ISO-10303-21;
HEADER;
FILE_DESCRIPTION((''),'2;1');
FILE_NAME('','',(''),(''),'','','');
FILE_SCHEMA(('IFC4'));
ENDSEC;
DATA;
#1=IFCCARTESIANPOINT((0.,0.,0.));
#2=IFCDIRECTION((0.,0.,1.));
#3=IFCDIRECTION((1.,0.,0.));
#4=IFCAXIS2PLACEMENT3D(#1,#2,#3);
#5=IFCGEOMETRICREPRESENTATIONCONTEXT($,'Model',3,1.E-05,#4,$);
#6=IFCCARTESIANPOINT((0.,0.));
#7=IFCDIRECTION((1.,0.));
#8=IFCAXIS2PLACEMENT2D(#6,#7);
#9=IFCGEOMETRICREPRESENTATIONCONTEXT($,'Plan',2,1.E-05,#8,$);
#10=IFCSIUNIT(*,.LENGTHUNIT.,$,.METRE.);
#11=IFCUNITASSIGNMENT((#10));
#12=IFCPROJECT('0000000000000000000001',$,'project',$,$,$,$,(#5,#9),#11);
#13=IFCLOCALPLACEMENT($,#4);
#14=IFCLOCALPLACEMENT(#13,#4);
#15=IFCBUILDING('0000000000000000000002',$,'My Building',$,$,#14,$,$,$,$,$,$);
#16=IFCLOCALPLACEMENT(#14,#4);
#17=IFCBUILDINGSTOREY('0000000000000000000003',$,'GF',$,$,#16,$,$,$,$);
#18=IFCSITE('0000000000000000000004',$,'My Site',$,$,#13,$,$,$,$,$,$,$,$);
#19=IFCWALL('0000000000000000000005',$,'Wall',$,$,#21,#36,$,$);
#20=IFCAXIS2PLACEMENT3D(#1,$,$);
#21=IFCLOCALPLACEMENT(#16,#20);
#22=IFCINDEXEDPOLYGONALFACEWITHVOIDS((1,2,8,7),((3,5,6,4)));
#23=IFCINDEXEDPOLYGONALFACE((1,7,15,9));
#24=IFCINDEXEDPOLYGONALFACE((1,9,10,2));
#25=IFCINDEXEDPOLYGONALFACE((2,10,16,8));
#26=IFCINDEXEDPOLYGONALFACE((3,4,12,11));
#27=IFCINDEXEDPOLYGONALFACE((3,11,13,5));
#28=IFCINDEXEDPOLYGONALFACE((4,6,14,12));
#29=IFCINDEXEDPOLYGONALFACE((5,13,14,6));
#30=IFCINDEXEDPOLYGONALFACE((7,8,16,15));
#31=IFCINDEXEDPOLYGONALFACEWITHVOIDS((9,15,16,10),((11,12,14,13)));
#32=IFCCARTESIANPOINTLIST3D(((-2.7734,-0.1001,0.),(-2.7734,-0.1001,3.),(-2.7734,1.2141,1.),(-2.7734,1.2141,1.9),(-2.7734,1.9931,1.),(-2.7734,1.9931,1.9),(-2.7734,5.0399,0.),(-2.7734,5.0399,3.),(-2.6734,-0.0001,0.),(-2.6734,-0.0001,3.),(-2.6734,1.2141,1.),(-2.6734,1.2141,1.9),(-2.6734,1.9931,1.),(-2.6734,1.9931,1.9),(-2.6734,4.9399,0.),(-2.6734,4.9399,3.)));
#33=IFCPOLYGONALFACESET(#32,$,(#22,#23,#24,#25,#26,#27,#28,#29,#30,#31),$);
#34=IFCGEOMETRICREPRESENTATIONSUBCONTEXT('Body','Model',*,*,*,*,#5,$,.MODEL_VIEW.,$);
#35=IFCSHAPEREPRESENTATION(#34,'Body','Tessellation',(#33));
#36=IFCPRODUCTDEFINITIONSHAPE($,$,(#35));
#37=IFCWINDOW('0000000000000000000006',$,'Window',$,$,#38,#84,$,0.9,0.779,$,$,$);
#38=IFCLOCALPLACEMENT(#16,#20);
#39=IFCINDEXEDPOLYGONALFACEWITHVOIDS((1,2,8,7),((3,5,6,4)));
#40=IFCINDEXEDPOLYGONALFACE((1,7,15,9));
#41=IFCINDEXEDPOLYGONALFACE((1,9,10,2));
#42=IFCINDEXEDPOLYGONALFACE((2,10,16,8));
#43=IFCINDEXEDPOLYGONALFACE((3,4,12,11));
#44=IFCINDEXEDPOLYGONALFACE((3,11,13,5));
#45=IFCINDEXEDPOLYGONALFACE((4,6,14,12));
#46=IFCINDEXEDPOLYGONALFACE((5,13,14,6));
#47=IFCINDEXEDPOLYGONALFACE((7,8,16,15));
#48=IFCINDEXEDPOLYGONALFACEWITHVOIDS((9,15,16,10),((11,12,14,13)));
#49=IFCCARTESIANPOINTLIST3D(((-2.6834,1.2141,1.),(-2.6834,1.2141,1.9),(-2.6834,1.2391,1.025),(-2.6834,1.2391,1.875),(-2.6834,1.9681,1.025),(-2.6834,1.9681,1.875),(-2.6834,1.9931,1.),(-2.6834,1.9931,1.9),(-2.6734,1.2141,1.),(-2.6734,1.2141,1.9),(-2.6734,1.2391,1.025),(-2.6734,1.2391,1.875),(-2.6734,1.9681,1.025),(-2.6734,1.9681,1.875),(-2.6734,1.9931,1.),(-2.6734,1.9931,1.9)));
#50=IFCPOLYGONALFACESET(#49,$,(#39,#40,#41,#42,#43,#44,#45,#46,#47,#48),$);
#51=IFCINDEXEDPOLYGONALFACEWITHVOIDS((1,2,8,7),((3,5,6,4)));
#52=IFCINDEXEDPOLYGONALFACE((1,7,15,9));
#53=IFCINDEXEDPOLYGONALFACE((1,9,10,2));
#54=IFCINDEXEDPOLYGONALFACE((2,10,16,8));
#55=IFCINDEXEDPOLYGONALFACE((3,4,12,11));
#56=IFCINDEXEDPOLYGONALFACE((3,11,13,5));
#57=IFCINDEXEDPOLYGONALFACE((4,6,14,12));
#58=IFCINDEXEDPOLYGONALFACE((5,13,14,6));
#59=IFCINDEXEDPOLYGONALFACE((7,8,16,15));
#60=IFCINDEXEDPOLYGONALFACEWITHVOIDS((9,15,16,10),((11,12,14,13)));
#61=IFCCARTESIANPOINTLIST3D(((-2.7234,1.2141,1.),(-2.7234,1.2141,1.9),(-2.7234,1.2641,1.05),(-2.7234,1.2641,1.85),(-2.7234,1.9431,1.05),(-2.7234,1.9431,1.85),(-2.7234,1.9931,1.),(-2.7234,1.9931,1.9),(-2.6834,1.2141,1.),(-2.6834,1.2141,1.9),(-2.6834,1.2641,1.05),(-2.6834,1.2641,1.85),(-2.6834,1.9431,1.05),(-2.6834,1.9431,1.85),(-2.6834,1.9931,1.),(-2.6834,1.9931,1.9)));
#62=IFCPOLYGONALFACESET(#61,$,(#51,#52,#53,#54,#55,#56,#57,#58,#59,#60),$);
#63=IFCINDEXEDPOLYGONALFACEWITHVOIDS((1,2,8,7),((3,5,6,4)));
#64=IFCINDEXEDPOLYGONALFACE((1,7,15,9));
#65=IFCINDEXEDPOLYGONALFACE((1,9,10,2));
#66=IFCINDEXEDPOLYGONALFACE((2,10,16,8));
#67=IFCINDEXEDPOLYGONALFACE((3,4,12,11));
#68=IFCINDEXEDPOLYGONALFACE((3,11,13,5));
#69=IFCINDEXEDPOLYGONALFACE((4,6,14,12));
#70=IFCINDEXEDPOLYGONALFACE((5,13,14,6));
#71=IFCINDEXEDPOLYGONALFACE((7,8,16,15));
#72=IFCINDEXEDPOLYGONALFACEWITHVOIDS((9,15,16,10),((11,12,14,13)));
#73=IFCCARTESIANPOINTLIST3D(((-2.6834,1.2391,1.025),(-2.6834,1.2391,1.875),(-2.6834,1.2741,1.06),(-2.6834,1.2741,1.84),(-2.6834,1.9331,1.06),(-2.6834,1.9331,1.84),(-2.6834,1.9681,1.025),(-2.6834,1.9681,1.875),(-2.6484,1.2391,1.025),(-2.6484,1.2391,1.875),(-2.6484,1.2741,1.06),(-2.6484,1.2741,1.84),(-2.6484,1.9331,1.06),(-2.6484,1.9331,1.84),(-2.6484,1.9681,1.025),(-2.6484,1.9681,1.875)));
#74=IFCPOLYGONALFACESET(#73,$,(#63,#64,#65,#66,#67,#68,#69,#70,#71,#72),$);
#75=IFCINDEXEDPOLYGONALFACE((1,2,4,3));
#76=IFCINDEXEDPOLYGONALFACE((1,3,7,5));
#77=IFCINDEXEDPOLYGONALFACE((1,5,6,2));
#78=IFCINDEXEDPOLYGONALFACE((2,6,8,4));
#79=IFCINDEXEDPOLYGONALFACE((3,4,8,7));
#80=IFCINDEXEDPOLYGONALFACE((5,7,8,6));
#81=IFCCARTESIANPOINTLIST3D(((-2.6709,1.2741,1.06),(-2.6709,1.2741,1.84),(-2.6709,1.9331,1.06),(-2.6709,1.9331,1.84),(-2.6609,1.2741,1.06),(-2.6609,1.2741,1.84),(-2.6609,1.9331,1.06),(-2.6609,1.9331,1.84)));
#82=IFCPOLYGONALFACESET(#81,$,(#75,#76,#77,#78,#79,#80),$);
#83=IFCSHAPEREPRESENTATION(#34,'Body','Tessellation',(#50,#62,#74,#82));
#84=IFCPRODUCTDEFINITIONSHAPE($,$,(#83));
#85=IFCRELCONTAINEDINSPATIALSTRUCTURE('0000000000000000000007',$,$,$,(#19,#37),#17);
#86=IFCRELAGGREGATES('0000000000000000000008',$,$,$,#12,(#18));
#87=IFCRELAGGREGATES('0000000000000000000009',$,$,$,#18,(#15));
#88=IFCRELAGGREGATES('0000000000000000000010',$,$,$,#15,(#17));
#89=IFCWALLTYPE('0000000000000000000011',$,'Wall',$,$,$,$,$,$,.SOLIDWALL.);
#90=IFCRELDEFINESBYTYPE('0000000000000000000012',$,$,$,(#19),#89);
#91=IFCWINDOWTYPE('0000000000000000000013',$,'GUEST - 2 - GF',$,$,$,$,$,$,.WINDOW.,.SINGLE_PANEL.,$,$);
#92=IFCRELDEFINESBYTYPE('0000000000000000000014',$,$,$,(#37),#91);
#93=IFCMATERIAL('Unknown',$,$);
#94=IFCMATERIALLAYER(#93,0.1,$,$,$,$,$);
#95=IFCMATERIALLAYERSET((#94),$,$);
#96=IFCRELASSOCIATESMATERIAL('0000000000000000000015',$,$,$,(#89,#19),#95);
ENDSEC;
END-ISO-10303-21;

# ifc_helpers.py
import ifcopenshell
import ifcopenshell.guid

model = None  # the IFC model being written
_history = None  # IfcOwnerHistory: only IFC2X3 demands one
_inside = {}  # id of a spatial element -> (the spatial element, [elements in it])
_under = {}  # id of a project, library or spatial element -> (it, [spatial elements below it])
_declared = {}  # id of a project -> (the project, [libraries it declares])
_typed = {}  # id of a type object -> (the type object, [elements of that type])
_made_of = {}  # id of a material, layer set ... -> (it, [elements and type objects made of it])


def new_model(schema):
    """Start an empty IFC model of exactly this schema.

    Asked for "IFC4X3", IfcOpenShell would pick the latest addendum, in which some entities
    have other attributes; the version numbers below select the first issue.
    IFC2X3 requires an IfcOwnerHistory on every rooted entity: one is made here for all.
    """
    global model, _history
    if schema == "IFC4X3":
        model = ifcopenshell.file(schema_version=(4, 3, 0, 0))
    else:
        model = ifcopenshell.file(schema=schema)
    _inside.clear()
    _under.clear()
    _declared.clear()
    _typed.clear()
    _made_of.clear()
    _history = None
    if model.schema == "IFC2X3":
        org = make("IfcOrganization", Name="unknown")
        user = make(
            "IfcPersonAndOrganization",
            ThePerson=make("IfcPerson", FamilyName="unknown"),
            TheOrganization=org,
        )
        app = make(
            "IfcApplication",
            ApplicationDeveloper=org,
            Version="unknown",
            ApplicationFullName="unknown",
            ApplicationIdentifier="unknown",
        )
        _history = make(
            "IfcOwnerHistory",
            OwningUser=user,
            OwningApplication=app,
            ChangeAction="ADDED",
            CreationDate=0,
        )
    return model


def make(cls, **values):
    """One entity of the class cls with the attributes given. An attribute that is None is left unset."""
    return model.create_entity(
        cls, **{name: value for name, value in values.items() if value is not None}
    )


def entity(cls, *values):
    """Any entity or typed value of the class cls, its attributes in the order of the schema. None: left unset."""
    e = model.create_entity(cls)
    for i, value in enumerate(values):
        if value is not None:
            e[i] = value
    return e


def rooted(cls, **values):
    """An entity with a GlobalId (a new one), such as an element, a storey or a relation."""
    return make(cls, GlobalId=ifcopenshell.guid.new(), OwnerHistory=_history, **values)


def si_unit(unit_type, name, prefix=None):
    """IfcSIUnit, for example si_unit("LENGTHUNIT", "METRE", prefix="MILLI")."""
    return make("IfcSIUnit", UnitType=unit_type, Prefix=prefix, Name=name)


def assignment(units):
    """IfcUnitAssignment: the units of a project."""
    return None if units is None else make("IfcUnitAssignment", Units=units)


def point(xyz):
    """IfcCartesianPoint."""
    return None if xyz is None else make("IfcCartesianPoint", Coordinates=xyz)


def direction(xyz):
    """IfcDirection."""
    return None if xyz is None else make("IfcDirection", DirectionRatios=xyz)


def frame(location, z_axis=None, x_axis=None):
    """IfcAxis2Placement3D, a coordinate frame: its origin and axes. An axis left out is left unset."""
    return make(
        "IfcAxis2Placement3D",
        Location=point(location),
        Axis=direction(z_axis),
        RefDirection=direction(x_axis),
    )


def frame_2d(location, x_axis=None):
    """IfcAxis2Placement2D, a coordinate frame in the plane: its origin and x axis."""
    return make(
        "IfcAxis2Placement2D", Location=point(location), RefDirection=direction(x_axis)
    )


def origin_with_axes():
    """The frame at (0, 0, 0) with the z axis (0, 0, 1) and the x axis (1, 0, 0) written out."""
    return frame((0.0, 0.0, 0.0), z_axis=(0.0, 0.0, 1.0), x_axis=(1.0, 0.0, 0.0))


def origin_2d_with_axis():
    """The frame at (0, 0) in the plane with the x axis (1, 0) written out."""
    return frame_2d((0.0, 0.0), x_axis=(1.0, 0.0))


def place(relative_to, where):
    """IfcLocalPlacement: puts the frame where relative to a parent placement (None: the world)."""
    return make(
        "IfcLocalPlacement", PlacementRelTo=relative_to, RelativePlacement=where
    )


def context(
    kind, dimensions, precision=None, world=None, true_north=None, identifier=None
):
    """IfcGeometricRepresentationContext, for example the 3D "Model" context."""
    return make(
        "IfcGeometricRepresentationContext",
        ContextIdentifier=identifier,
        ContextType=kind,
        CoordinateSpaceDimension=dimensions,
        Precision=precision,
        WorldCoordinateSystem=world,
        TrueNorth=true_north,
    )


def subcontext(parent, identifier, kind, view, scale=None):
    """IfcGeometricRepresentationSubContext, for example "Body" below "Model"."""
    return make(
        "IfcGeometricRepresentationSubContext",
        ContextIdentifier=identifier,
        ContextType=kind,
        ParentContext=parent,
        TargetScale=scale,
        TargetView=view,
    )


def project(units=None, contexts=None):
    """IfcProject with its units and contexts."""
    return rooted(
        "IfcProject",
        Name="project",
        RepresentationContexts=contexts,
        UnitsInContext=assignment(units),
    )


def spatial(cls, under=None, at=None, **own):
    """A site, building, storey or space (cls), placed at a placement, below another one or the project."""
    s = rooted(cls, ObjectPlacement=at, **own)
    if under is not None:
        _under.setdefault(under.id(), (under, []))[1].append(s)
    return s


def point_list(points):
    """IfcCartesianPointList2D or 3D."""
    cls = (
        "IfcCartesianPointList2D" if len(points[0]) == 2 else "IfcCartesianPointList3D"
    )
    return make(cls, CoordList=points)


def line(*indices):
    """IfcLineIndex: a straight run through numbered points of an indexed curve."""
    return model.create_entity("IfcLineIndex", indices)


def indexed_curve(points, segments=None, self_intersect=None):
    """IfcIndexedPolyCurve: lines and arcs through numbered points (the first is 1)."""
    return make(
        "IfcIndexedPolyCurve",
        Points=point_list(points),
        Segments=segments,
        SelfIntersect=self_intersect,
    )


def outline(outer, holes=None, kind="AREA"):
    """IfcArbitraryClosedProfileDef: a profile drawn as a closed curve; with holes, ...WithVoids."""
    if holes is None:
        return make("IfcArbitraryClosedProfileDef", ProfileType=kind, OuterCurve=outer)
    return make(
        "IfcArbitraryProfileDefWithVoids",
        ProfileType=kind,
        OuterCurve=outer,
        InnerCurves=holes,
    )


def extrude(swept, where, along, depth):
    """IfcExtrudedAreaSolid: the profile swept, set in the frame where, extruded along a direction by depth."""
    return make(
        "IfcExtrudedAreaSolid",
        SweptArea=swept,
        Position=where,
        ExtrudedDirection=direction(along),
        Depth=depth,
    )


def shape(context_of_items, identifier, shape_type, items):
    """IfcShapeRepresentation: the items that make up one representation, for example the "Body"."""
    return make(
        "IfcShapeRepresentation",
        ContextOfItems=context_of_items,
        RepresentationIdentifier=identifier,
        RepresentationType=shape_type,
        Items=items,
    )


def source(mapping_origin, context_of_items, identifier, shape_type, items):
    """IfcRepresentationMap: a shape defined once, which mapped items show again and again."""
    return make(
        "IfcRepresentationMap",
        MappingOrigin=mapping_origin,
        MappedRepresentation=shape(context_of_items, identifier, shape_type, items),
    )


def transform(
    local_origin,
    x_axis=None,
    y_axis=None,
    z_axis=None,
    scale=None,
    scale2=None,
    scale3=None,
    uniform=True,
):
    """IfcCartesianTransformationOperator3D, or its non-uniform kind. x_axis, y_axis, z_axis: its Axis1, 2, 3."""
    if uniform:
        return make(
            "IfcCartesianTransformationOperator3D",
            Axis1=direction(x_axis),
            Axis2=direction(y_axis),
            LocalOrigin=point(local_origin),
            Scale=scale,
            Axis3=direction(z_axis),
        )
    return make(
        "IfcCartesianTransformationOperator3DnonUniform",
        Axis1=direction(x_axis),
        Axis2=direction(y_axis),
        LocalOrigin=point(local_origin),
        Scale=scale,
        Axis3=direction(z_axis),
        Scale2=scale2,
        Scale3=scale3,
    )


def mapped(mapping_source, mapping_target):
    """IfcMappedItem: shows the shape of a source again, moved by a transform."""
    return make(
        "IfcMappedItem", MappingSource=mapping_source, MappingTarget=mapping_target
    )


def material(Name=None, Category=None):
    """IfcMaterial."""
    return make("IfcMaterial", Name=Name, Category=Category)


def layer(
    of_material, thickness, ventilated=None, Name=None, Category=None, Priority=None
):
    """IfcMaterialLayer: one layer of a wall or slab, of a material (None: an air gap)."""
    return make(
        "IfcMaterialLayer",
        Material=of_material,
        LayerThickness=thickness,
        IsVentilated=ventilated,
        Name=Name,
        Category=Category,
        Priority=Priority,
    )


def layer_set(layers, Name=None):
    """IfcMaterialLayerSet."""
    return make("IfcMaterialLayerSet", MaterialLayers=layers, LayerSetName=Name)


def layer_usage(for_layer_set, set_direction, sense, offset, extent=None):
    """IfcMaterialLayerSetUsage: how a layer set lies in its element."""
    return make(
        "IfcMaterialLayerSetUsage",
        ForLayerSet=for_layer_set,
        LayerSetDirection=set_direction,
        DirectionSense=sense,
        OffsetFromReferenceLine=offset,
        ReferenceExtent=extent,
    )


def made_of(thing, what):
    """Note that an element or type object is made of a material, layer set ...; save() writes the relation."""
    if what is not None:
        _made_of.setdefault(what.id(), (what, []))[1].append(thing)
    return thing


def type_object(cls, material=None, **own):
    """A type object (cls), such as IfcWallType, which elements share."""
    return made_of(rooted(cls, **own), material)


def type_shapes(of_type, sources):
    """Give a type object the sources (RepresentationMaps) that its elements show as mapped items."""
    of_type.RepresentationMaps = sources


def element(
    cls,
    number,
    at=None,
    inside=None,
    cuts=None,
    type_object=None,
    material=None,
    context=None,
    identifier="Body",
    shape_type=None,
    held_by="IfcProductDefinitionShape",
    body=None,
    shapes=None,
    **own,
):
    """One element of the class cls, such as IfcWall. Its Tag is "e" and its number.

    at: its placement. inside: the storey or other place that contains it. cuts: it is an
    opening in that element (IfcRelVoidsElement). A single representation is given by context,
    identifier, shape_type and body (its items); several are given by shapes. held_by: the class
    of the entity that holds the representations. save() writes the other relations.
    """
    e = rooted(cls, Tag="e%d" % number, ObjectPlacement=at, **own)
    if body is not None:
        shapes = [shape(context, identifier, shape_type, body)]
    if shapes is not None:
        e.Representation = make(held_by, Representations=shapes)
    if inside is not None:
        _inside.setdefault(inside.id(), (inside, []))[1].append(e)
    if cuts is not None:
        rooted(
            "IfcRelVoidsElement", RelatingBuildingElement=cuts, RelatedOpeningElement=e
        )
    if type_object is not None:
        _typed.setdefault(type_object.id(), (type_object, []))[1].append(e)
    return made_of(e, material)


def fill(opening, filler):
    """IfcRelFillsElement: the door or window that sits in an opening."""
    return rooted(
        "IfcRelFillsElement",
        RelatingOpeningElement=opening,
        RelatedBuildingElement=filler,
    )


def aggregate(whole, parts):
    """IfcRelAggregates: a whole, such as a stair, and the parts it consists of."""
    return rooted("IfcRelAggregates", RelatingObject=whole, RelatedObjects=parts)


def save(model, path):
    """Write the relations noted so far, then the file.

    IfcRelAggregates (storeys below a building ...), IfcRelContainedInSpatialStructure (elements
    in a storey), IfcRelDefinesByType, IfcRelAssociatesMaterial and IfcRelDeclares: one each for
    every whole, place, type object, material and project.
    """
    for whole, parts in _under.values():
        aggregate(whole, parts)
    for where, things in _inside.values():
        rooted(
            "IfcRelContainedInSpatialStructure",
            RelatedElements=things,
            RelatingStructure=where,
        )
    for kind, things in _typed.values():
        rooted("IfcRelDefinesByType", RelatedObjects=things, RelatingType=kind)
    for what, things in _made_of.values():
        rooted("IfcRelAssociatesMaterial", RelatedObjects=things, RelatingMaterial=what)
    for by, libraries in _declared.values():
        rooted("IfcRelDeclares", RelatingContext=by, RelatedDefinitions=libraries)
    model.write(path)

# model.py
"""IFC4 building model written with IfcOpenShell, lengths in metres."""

from ifc_helpers import new_model, entity, si_unit, frame, origin_with_axes, origin_2d_with_axis, place, context, subcontext, project, spatial, line, indexed_curve, outline, extrude, shape, source, transform, mapped, material, layer, layer_set, layer_usage, type_object, type_shapes, element, fill, save


model = new_model("IFC4")

# Units and contexts
model_context = context("Model", 3, precision=1e-05, world=origin_with_axes())
plan_context = context("Plan", 2, precision=1e-05, world=origin_2d_with_axis())
body_context_1 = subcontext(model_context, "Body", "Model", "MODEL_VIEW")
body_context_2 = subcontext(plan_context, "Body", "Plan", "PLAN_VIEW")
ifc_project = project(units=[si_unit("LENGTHUNIT", "METRE")], contexts=[model_context, plan_context])

# Site, building, storey
site_placement = place(None, origin_with_axes())
site = spatial("IfcSite", under=ifc_project, at=site_placement, Name="My Site")
building_placement = place(site_placement, origin_with_axes())
building = spatial("IfcBuilding", under=site, at=building_placement, Name="My Building")
storey_placement = place(building_placement, origin_with_axes())
storey = spatial("IfcBuildingStorey", under=building, at=storey_placement, Name="GF")

# Shared definitions
ifc_material = material(Name="Unknown")

# Shared definitions
ifc_layer_1 = layer(ifc_material, 0.1)
ifc_layer_set_1 = layer_set([ifc_layer_1])
wall_type = type_object("IfcWallType", Name="Wall", PredefinedType="SOLIDWALL", material=ifc_layer_set_1)

# Wall, opening, window
ifc_layer_usage_1 = layer_usage(ifc_layer_set_1, "AXIS2", "POSITIVE", 0.0)
wall_1_placement = place(storey_placement, frame((-2.7734, 5.0399, 0.0), z_axis=(0.0, 0.0, 1.0), x_axis=(0.0, -1.0, 0.0)))
wall_1 = element("IfcWall", 1, at=wall_1_placement, inside=storey, type_object=wall_type, material=ifc_layer_usage_1, Name="Wall", context=body_context_1, shape_type="SweptSolid", body=[
    extrude(outline(indexed_curve([(0.0, 0.0), (0.1, 0.1), (5.04, 0.1), (5.14, 0.0)], segments=[line(1, 2, 3, 4, 1)])), origin_with_axes(), (0.0, 0.0, 1.0), 3.0),
])
shared_shape_1 = source(origin_with_axes(), body_context_1, "Body", "SweptSolid", [
    extrude(outline(indexed_curve([(0.0, 0.0), (0.779, 0.0), (0.779, 0.9), (0.0, 0.9)], segments=[line(1, 2, 3, 4, 1)])), frame((0.0, -0.6, 0.0), z_axis=(0.0, -1.0, 0.0), x_axis=(1.0, 0.0, 0.0)), (0.0, 0.0, -1.0), 1.2),
])
opening_1_placement = place(wall_1_placement, frame((3.0468, 0.0, 1.0), z_axis=(0.0, 0.0, 1.0), x_axis=(1.0, 0.0, 0.0)))
opening_1 = element("IfcOpeningElement", 2, at=opening_1_placement, cuts=wall_1, PredefinedType="OPENING", context=body_context_1, shape_type="MappedRepresentation", body=[
    mapped(shared_shape_1, transform((0.0, 0.0, 0.0), x_axis=(1.0, 0.0, 0.0), y_axis=(0.0, 1.0, 0.0), z_axis=(0.0, 0.0, 1.0), scale=1.0)),
])
window_type_1 = type_object("IfcWindowType", Name="GUEST - 2 - GF", PartitioningType="SINGLE_PANEL", PredefinedType="WINDOW")
shared_shape_2 = source(origin_with_axes(), body_context_1, "Body", "SweptSolid", [
    extrude(outline(indexed_curve([(0.0, 0.0), (0.779, 0.0), (0.779, 0.9), (0.0, 0.9)], segments=[line(1, 2, 3, 4, 1)]), holes=[indexed_curve([(0.025, 0.025), (0.754, 0.025), (0.754, 0.875), (0.025, 0.875)], segments=[line(1, 2, 3, 4, 1)])]), frame((0.0, 0.09, 0.0), z_axis=(0.0, -1.0, 0.0), x_axis=(1.0, 0.0, 0.0)), (0.0, 0.0, -1.0), 0.01),
    extrude(outline(indexed_curve([(0.0, 0.0), (0.779, 0.0), (0.779, 0.9), (0.0, 0.9)], segments=[line(1, 2, 3, 4, 1)]), holes=[indexed_curve([(0.05, 0.05), (0.729, 0.05), (0.729, 0.85), (0.05, 0.85)], segments=[line(1, 2, 3, 4, 1)])]), frame((0.0, 0.05, 0.0), z_axis=(0.0, -1.0, 0.0), x_axis=(1.0, 0.0, 0.0)), (0.0, 0.0, -1.0), 0.04),
    extrude(outline(indexed_curve([(0.0, 0.0), (0.729, 0.0), (0.729, 0.85), (0.0, 0.85)], segments=[line(1, 2, 3, 4, 1)]), holes=[indexed_curve([(0.035, 0.035), (0.694, 0.035), (0.694, 0.815), (0.035, 0.815)], segments=[line(1, 2, 3, 4, 1)])]), frame((0.025, 0.09, 0.025), z_axis=(0.0, -1.0, 0.0), x_axis=(1.0, 0.0, 0.0)), (0.0, 0.0, -1.0), 0.035),
    extrude(outline(indexed_curve([(0.035, 0.035), (0.694, 0.035), (0.694, 0.815), (0.035, 0.815)], segments=[line(1, 2, 3, 4, 1)])), frame((0.025, 0.1025, 0.025), z_axis=(0.0, -1.0, 0.0), x_axis=(1.0, 0.0, 0.0)), (0.0, 0.0, -1.0), 0.01),
])
shared_shape_3 = source(origin_with_axes(), body_context_2, "Body", "Curve2D", [
    entity("IfcIndexedPolyCurve", entity("IfcCartesianPointList2D", [[0.05, 0.05], [0.729, 0.05]])),
    entity("IfcIndexedPolyCurve", entity("IfcCartesianPointList2D", [[0.0, 0.1], [0.025, 0.1], [0.025, 0.09], [0.05, 0.09], [0.05, 0.05], [0.0, 0.05]]), [entity("IfcLineIndex", [1, 2, 3, 4, 5, 6, 1])]),
    entity("IfcIndexedPolyCurve", entity("IfcCartesianPointList2D", [[0.779, 0.1], [0.754, 0.1], [0.754, 0.09], [0.729, 0.09], [0.729, 0.05], [0.779, 0.05]]), [entity("IfcLineIndex", [1, 2, 3, 4, 5, 6, 1])]),
    entity("IfcIndexedPolyCurve", entity("IfcCartesianPointList2D", [[0.025, 0.09], [0.06, 0.09], [0.06, 0.125], [0.025, 0.125]]), [entity("IfcLineIndex", [1, 2, 3, 4, 1])]),
    entity("IfcIndexedPolyCurve", entity("IfcCartesianPointList2D", [[0.754, 0.09], [0.719, 0.09], [0.719, 0.125], [0.754, 0.125]]), [entity("IfcLineIndex", [1, 2, 3, 4, 1])]),
    entity("IfcIndexedPolyCurve", entity("IfcCartesianPointList2D", [[0.06, 0.09], [0.719, 0.09]])),
    entity("IfcIndexedPolyCurve", entity("IfcCartesianPointList2D", [[0.06, 0.125], [0.719, 0.125]])),
    entity("IfcIndexedPolyCurve", entity("IfcCartesianPointList2D", [[0.06, 0.1075], [0.719, 0.1075]])),
])
type_shapes(window_type_1, [shared_shape_2, shared_shape_3])
window_1_placement = place(opening_1_placement, frame((0.0, 0.0, 0.0), z_axis=(0.0, 0.0, 1.0), x_axis=(1.0, 0.0, 0.0)))
window_1 = element("IfcWindow", 3, at=window_1_placement, inside=storey, type_object=window_type_1, Name="Window", OverallHeight=0.9, OverallWidth=0.779, shapes=[
    shape(body_context_1, "Body", "MappedRepresentation", [mapped(shared_shape_2, transform((0.0, 0.0, 0.0), x_axis=(1.0, 0.0, 0.0), y_axis=(0.0, 1.0, 0.0), z_axis=(0.0, 0.0, 1.0), scale=1.0))]),
    shape(body_context_2, "Body", "MappedRepresentation", [mapped(shared_shape_3, transform((0.0, 0.0, 0.0), x_axis=(1.0, 0.0, 0.0), y_axis=(0.0, 1.0, 0.0), z_axis=(0.0, 0.0, 1.0), scale=1.0))]),
])
fill(opening_1, window_1)

save(model, "model.ifc")
